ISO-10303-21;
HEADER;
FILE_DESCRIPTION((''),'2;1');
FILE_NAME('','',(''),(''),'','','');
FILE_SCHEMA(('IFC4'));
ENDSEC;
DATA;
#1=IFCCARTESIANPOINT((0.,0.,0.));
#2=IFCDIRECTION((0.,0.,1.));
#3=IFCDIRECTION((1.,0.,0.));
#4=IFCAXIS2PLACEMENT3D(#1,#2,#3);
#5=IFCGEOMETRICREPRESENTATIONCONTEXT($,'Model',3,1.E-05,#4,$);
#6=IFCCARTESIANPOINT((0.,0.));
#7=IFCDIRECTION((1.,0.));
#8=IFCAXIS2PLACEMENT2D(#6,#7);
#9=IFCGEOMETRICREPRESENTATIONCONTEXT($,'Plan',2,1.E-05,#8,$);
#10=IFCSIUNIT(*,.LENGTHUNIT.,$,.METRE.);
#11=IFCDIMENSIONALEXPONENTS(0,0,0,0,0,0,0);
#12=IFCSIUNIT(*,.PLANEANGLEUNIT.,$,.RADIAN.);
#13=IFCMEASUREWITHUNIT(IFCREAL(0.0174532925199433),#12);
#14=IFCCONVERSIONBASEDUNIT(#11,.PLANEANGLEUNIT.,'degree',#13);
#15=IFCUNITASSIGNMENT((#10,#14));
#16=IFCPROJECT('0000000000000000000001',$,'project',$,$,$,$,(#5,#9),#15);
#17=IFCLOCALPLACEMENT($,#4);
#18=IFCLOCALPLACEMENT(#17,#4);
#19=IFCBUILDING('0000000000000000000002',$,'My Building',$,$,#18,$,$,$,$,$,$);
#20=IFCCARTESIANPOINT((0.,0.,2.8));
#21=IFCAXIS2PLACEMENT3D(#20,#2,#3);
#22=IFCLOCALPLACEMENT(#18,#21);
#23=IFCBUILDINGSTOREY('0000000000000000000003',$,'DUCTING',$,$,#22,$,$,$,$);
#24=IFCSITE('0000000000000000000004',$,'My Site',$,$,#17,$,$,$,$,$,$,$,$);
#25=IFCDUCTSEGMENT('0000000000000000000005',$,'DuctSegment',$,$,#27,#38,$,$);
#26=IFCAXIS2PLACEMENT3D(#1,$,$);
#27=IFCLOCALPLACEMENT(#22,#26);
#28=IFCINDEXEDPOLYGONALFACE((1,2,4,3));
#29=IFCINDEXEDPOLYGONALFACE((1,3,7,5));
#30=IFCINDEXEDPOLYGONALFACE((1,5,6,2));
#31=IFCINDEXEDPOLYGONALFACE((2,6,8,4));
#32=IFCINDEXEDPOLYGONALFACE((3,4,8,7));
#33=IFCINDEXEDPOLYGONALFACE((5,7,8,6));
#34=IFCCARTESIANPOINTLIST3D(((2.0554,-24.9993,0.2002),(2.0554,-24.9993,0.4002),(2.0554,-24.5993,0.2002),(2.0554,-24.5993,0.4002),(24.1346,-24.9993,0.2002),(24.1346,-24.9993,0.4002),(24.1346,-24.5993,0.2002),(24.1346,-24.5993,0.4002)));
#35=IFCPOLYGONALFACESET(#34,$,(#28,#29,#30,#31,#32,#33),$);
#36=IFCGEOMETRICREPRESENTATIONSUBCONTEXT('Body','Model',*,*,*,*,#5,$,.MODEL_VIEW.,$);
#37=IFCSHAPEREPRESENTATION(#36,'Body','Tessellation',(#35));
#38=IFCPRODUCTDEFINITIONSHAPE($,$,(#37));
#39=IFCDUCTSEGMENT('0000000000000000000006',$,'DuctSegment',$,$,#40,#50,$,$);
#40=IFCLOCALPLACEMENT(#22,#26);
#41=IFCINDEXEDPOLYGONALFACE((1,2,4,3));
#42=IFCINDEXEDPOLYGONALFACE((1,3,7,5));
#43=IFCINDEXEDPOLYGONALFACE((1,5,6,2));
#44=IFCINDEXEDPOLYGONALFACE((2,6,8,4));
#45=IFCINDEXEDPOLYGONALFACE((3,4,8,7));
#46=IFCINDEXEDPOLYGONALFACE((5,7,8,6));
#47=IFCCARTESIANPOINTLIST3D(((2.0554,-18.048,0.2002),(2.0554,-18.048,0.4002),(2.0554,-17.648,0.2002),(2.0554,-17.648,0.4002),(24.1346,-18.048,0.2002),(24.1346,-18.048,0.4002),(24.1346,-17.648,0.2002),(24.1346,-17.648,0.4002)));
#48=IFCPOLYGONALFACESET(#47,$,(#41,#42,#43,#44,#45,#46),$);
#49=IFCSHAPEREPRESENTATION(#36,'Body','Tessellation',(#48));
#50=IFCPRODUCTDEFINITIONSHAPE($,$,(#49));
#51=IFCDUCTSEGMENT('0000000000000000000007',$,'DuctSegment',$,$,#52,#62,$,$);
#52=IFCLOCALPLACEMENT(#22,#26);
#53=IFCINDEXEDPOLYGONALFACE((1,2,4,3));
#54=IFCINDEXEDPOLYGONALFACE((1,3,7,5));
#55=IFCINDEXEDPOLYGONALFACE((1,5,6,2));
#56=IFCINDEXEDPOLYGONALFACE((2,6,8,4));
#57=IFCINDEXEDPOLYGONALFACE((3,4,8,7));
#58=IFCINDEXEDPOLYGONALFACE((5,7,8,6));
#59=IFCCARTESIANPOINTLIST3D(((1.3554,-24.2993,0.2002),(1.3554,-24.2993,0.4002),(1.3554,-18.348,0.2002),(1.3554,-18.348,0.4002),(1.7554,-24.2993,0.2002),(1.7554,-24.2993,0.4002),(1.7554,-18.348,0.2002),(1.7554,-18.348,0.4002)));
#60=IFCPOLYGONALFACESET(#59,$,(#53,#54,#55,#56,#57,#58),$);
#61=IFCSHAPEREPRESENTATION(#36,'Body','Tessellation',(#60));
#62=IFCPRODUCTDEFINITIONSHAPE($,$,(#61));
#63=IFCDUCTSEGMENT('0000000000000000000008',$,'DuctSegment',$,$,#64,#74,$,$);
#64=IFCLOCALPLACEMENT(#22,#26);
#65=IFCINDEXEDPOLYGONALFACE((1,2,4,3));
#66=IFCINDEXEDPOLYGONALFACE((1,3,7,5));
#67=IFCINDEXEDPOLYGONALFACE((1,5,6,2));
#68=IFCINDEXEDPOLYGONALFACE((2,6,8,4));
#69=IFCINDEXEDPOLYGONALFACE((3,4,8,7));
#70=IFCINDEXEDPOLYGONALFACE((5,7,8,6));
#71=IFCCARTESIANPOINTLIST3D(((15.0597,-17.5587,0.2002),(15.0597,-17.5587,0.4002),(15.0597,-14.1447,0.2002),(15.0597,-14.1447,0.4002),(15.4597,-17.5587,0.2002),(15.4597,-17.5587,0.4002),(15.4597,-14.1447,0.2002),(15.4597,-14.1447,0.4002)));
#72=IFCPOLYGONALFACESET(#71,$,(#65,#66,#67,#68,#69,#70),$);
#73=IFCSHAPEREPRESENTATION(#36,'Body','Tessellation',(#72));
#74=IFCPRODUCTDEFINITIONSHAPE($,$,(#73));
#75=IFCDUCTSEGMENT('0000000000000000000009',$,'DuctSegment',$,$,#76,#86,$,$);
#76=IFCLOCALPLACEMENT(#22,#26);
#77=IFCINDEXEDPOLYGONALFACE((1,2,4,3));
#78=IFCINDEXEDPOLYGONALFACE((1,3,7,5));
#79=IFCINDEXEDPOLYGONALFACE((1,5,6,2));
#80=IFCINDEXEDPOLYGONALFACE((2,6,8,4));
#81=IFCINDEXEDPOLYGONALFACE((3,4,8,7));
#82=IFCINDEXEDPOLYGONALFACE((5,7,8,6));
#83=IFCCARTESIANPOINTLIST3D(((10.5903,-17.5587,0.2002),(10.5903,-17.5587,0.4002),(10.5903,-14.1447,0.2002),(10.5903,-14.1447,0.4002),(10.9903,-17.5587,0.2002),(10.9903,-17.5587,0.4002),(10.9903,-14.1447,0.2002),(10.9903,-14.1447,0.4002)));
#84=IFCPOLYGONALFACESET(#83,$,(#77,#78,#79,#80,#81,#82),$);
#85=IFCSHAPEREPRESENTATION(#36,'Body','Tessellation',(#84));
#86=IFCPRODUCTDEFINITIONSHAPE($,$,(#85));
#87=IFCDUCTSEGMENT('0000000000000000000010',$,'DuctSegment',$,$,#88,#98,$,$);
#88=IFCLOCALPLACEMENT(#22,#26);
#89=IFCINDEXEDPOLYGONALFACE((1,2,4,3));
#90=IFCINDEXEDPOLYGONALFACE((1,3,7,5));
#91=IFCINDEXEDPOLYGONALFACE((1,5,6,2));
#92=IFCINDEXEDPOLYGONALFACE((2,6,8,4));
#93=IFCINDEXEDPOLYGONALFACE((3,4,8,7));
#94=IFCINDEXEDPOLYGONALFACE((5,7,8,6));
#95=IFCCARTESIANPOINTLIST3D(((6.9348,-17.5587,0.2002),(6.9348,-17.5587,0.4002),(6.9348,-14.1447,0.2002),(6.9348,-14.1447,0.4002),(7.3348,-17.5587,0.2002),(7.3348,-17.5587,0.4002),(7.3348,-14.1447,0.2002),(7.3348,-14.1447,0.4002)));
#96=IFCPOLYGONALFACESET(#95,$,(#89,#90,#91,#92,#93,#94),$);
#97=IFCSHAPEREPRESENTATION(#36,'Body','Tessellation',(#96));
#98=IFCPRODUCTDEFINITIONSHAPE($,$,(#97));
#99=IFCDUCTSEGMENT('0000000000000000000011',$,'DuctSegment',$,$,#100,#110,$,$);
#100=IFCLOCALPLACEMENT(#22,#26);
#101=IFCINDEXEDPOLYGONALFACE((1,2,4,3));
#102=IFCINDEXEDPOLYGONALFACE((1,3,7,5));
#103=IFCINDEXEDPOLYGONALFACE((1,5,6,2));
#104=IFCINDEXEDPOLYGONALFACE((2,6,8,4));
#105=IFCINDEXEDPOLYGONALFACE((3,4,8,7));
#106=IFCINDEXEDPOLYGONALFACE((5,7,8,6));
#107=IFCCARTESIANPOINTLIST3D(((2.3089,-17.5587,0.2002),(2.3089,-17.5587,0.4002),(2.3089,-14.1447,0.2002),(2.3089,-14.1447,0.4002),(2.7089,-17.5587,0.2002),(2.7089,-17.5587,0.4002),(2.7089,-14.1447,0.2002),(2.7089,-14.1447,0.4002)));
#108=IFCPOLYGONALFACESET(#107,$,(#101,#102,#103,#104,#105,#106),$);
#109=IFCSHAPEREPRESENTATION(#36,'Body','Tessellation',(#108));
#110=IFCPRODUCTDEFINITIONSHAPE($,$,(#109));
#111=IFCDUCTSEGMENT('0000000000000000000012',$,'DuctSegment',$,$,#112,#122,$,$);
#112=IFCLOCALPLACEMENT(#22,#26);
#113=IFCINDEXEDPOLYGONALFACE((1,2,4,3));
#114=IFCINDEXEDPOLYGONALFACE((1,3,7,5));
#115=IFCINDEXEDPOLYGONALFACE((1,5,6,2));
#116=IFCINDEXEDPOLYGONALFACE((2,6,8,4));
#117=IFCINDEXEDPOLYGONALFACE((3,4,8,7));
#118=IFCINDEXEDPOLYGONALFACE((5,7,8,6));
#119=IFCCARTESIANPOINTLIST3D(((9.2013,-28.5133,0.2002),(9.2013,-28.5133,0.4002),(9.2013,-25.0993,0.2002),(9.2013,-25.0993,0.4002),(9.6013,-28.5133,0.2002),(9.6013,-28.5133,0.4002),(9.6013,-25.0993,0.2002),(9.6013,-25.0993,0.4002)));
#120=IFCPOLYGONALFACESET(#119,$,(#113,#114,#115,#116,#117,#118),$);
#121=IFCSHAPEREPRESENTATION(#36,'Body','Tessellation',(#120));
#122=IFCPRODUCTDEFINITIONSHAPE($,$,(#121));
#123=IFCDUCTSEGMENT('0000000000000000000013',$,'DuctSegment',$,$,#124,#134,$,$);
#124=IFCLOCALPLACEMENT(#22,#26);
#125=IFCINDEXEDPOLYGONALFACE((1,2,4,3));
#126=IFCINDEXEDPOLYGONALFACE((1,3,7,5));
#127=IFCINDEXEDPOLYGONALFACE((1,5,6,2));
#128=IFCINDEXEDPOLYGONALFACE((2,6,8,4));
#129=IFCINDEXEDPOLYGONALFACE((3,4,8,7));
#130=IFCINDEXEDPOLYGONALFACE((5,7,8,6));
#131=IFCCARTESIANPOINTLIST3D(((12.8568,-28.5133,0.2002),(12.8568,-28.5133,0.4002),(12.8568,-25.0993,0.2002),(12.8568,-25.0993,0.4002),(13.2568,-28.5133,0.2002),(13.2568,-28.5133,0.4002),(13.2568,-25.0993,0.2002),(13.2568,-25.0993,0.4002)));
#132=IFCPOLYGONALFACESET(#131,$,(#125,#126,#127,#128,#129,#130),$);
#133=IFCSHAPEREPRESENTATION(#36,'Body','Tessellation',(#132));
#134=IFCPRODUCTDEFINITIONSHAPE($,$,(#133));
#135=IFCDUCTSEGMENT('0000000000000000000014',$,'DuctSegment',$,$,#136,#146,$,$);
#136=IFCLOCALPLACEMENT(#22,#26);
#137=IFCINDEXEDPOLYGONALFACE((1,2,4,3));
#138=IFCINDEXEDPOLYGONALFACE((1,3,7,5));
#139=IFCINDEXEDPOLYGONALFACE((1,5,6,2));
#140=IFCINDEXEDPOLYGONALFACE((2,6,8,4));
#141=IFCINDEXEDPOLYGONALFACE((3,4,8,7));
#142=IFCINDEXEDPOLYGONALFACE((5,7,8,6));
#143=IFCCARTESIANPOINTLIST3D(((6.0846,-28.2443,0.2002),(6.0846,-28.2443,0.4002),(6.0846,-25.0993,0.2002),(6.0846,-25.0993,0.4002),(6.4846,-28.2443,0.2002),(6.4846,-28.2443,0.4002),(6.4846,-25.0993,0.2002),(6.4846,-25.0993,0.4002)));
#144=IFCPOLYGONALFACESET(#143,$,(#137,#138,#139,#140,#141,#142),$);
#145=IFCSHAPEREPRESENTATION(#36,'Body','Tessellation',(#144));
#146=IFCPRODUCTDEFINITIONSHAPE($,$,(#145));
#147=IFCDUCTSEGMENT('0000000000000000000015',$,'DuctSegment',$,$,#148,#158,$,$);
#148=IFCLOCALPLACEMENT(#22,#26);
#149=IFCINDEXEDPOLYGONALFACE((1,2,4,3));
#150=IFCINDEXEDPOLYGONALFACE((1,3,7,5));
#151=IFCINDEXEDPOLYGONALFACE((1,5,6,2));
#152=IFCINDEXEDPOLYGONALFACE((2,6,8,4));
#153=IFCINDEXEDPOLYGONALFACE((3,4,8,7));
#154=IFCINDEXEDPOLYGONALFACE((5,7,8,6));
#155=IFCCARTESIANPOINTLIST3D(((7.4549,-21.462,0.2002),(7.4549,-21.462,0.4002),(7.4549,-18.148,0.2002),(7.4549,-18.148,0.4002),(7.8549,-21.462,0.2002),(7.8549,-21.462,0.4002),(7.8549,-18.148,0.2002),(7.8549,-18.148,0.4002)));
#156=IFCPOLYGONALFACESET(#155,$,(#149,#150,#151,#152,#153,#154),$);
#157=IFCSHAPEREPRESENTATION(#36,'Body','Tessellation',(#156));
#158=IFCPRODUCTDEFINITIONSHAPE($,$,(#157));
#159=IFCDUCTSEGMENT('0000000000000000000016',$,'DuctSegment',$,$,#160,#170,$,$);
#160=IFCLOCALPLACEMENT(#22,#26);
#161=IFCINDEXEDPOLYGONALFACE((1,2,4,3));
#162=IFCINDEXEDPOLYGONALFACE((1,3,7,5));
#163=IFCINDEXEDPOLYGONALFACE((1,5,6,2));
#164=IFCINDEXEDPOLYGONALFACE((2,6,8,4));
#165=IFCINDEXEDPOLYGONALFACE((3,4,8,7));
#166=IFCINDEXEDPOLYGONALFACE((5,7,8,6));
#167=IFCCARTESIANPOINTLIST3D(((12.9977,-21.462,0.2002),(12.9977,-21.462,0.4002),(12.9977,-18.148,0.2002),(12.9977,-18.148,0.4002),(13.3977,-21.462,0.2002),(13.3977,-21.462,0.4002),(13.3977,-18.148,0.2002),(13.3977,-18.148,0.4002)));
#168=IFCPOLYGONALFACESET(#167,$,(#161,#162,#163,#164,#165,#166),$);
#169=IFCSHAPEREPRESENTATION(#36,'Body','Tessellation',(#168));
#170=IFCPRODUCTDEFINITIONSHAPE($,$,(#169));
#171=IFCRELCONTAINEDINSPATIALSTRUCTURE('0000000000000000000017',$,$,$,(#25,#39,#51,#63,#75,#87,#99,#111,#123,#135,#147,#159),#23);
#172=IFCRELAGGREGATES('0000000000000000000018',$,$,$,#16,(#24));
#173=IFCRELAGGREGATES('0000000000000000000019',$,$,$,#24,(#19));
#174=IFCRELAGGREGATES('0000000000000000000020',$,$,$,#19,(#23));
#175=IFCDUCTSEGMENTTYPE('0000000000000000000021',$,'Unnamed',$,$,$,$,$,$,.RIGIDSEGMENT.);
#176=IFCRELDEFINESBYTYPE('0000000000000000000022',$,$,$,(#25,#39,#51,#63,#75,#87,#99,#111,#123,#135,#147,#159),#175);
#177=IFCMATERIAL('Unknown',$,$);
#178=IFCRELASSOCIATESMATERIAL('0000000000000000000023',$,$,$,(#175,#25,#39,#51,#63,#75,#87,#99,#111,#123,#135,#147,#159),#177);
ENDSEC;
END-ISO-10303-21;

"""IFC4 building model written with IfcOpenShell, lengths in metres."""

from ifc_helpers import new_model, entity, si_unit, converted_unit, frame, origin_with_axes, origin_2d_with_axis, place, context, subcontext, project, spatial, rectangle, extrude, material, material_profile, profile_set, profile_usage, type_object, element, save


model = new_model("IFC4")

# Units and contexts
model_context = context("Model", 3, precision=1e-05, world=origin_with_axes())
plan_context = context("Plan", 2, precision=1e-05, world=origin_2d_with_axis())
body_context = subcontext(model_context, "Body", "Model", "MODEL_VIEW")
ifc_project = project(units=[si_unit("LENGTHUNIT", "METRE"), converted_unit("PLANEANGLEUNIT", "degree", entity("IfcReal", 0.0174532925199433), si_unit("PLANEANGLEUNIT", "RADIAN"), dimensions=[0, 0, 0, 0, 0, 0, 0])], contexts=[model_context, plan_context])

# Site, building, storey
site_placement = place(None, origin_with_axes())
site = spatial("IfcSite", under=ifc_project, at=site_placement, Name="My Site")
building_placement = place(site_placement, origin_with_axes())
building = spatial("IfcBuilding", under=site, at=building_placement, Name="My Building")
storey_placement = place(building_placement, frame((0.0, 0.0, 2.8), z_axis=(0.0, 0.0, 1.0), x_axis=(1.0, 0.0, 0.0)))
storey = spatial("IfcBuildingStorey", under=building, at=storey_placement, Name="DUCTING")

# Duct segments
ifc_material = material(Name="Unknown")
ifc_material_profile_1 = material_profile(ifc_material, rectangle(XDim=0.4, YDim=0.2))
ifc_profile_set_1 = profile_set([ifc_material_profile_1])
ifc_profile_usage_1 = profile_usage(ifc_profile_set_1, cardinal=5)
duct_segment_type = type_object("IfcDuctSegmentType", Name="Unnamed", PredefinedType="RIGIDSEGMENT", material=ifc_profile_set_1)
duct_segment_1_placement = place(storey_placement, frame((2.0554, -24.7993, 0.3002), z_axis=(1.0, -0.000001, 0.000001), x_axis=(0.000001, 1.0, 0.0)))
element("IfcDuctSegment", 1, at=duct_segment_1_placement, inside=storey, type_object=duct_segment_type, material=ifc_profile_usage_1, Name="DuctSegment", context=body_context, shape_type="SweptSolid", body=[
    extrude(rectangle(XDim=0.4, YDim=0.2), origin_with_axes(), (0.0, 0.0, 1.0), 22.0792),
])
ifc_profile_usage_2 = profile_usage(ifc_profile_set_1, cardinal=5)
duct_segment_2_placement = place(storey_placement, frame((2.0554, -17.848, 0.3002), z_axis=(1.0, -0.000001, 0.000001), x_axis=(0.000001, 1.0, 0.0)))
element("IfcDuctSegment", 2, at=duct_segment_2_placement, inside=storey, type_object=duct_segment_type, material=ifc_profile_usage_2, Name="DuctSegment", context=body_context, shape_type="SweptSolid", body=[
    extrude(rectangle(XDim=0.4, YDim=0.2), origin_with_axes(), (0.0, 0.0, 1.0), 22.0792),
])
ifc_profile_usage_3 = profile_usage(ifc_profile_set_1, cardinal=5)
duct_segment_3_placement = place(storey_placement, frame((1.5554, -18.348, 0.3002), z_axis=(0.0, -1.0, 0.0), x_axis=(1.0, 0.0, 0.0)))
element("IfcDuctSegment", 3, at=duct_segment_3_placement, inside=storey, type_object=duct_segment_type, material=ifc_profile_usage_3, Name="DuctSegment", context=body_context, shape_type="SweptSolid", body=[
    extrude(rectangle(XDim=0.4, YDim=0.2), origin_with_axes(), (0.0, 0.0, 1.0), 5.9513),
])
ifc_profile_usage_4 = profile_usage(ifc_profile_set_1, cardinal=5)
duct_segment_4_placement = place(storey_placement, frame((15.2597, -17.5587, 0.3002), z_axis=(0.0, 1.0, 0.0), x_axis=(-1.0, 0.0, 0.0)))
element("IfcDuctSegment", 4, at=duct_segment_4_placement, inside=storey, type_object=duct_segment_type, material=ifc_profile_usage_4, Name="DuctSegment", context=body_context, shape_type="SweptSolid", body=[
    extrude(rectangle(XDim=0.4, YDim=0.2), origin_with_axes(), (0.0, 0.0, 1.0), 3.4141),
])
ifc_profile_usage_5 = profile_usage(ifc_profile_set_1, cardinal=5)
duct_segment_5_placement = place(storey_placement, frame((10.7903, -17.5587, 0.3002), z_axis=(0.0, 1.0, 0.0), x_axis=(-1.0, 0.0, 0.0)))
element("IfcDuctSegment", 5, at=duct_segment_5_placement, inside=storey, type_object=duct_segment_type, material=ifc_profile_usage_5, Name="DuctSegment", context=body_context, shape_type="SweptSolid", body=[
    extrude(rectangle(XDim=0.4, YDim=0.2), origin_with_axes(), (0.0, 0.0, 1.0), 3.4141),
])
ifc_profile_usage_6 = profile_usage(ifc_profile_set_1, cardinal=5)
duct_segment_6_placement = place(storey_placement, frame((7.1348, -17.5587, 0.3002), z_axis=(0.0, 1.0, 0.0), x_axis=(-1.0, 0.0, 0.0)))
element("IfcDuctSegment", 6, at=duct_segment_6_placement, inside=storey, type_object=duct_segment_type, material=ifc_profile_usage_6, Name="DuctSegment", context=body_context, shape_type="SweptSolid", body=[
    extrude(rectangle(XDim=0.4, YDim=0.2), origin_with_axes(), (0.0, 0.0, 1.0), 3.4141),
])
ifc_profile_usage_7 = profile_usage(ifc_profile_set_1, cardinal=5)
duct_segment_7_placement = place(storey_placement, frame((2.5089, -17.5587, 0.3002), z_axis=(0.0, 1.0, 0.0), x_axis=(-1.0, 0.0, 0.0)))
element("IfcDuctSegment", 7, at=duct_segment_7_placement, inside=storey, type_object=duct_segment_type, material=ifc_profile_usage_7, Name="DuctSegment", context=body_context, shape_type="SweptSolid", body=[
    extrude(rectangle(XDim=0.4, YDim=0.2), origin_with_axes(), (0.0, 0.0, 1.0), 3.4141),
])
ifc_profile_usage_8 = profile_usage(ifc_profile_set_1, cardinal=5)
duct_segment_8_placement = place(storey_placement, frame((9.4013, -25.0993, 0.3002), z_axis=(0.0, -1.0, 0.0), x_axis=(1.0, 0.0, 0.0)))
element("IfcDuctSegment", 8, at=duct_segment_8_placement, inside=storey, type_object=duct_segment_type, material=ifc_profile_usage_8, Name="DuctSegment", context=body_context, shape_type="SweptSolid", body=[
    extrude(rectangle(XDim=0.4, YDim=0.2), origin_with_axes(), (0.0, 0.0, 1.0), 3.4141),
])
ifc_profile_usage_9 = profile_usage(ifc_profile_set_1, cardinal=5)
duct_segment_9_placement = place(storey_placement, frame((13.0568, -25.0993, 0.3002), z_axis=(0.0, -1.0, 0.0), x_axis=(1.0, 0.0, 0.0)))
element("IfcDuctSegment", 9, at=duct_segment_9_placement, inside=storey, type_object=duct_segment_type, material=ifc_profile_usage_9, Name="DuctSegment", context=body_context, shape_type="SweptSolid", body=[
    extrude(rectangle(XDim=0.4, YDim=0.2), origin_with_axes(), (0.0, 0.0, 1.0), 3.4141),
])
ifc_profile_usage_10 = profile_usage(ifc_profile_set_1, cardinal=5)
duct_segment_10_placement = place(storey_placement, frame((6.2846, -28.2443, 0.3002), z_axis=(0.0, 1.0, 0.0), x_axis=(-1.0, 0.0, 0.0)))
element("IfcDuctSegment", 10, at=duct_segment_10_placement, inside=storey, type_object=duct_segment_type, material=ifc_profile_usage_10, Name="DuctSegment", context=body_context, shape_type="SweptSolid", body=[
    extrude(rectangle(XDim=0.4, YDim=0.2), origin_with_axes(), (0.0, 0.0, 1.0), 3.145),
])
ifc_profile_usage_11 = profile_usage(ifc_profile_set_1, cardinal=5)
duct_segment_11_placement = place(storey_placement, frame((7.6549, -18.148, 0.3002), z_axis=(0.0, -1.0, 0.0), x_axis=(1.0, 0.0, 0.0)))
element("IfcDuctSegment", 11, at=duct_segment_11_placement, inside=storey, type_object=duct_segment_type, material=ifc_profile_usage_11, Name="DuctSegment", context=body_context, shape_type="SweptSolid", body=[
    extrude(rectangle(XDim=0.4, YDim=0.2), origin_with_axes(), (0.0, 0.0, 1.0), 3.3141),
])
ifc_profile_usage_12 = profile_usage(ifc_profile_set_1, cardinal=5)
duct_segment_12_placement = place(storey_placement, frame((13.1977, -18.148, 0.3002), z_axis=(0.0, -1.0, 0.0), x_axis=(1.0, 0.0, 0.0)))
element("IfcDuctSegment", 12, at=duct_segment_12_placement, inside=storey, type_object=duct_segment_type, material=ifc_profile_usage_12, Name="DuctSegment", context=body_context, shape_type="SweptSolid", body=[
    extrude(rectangle(XDim=0.4, YDim=0.2), origin_with_axes(), (0.0, 0.0, 1.0), 3.3141),
])

save(model, "model.ifc")
